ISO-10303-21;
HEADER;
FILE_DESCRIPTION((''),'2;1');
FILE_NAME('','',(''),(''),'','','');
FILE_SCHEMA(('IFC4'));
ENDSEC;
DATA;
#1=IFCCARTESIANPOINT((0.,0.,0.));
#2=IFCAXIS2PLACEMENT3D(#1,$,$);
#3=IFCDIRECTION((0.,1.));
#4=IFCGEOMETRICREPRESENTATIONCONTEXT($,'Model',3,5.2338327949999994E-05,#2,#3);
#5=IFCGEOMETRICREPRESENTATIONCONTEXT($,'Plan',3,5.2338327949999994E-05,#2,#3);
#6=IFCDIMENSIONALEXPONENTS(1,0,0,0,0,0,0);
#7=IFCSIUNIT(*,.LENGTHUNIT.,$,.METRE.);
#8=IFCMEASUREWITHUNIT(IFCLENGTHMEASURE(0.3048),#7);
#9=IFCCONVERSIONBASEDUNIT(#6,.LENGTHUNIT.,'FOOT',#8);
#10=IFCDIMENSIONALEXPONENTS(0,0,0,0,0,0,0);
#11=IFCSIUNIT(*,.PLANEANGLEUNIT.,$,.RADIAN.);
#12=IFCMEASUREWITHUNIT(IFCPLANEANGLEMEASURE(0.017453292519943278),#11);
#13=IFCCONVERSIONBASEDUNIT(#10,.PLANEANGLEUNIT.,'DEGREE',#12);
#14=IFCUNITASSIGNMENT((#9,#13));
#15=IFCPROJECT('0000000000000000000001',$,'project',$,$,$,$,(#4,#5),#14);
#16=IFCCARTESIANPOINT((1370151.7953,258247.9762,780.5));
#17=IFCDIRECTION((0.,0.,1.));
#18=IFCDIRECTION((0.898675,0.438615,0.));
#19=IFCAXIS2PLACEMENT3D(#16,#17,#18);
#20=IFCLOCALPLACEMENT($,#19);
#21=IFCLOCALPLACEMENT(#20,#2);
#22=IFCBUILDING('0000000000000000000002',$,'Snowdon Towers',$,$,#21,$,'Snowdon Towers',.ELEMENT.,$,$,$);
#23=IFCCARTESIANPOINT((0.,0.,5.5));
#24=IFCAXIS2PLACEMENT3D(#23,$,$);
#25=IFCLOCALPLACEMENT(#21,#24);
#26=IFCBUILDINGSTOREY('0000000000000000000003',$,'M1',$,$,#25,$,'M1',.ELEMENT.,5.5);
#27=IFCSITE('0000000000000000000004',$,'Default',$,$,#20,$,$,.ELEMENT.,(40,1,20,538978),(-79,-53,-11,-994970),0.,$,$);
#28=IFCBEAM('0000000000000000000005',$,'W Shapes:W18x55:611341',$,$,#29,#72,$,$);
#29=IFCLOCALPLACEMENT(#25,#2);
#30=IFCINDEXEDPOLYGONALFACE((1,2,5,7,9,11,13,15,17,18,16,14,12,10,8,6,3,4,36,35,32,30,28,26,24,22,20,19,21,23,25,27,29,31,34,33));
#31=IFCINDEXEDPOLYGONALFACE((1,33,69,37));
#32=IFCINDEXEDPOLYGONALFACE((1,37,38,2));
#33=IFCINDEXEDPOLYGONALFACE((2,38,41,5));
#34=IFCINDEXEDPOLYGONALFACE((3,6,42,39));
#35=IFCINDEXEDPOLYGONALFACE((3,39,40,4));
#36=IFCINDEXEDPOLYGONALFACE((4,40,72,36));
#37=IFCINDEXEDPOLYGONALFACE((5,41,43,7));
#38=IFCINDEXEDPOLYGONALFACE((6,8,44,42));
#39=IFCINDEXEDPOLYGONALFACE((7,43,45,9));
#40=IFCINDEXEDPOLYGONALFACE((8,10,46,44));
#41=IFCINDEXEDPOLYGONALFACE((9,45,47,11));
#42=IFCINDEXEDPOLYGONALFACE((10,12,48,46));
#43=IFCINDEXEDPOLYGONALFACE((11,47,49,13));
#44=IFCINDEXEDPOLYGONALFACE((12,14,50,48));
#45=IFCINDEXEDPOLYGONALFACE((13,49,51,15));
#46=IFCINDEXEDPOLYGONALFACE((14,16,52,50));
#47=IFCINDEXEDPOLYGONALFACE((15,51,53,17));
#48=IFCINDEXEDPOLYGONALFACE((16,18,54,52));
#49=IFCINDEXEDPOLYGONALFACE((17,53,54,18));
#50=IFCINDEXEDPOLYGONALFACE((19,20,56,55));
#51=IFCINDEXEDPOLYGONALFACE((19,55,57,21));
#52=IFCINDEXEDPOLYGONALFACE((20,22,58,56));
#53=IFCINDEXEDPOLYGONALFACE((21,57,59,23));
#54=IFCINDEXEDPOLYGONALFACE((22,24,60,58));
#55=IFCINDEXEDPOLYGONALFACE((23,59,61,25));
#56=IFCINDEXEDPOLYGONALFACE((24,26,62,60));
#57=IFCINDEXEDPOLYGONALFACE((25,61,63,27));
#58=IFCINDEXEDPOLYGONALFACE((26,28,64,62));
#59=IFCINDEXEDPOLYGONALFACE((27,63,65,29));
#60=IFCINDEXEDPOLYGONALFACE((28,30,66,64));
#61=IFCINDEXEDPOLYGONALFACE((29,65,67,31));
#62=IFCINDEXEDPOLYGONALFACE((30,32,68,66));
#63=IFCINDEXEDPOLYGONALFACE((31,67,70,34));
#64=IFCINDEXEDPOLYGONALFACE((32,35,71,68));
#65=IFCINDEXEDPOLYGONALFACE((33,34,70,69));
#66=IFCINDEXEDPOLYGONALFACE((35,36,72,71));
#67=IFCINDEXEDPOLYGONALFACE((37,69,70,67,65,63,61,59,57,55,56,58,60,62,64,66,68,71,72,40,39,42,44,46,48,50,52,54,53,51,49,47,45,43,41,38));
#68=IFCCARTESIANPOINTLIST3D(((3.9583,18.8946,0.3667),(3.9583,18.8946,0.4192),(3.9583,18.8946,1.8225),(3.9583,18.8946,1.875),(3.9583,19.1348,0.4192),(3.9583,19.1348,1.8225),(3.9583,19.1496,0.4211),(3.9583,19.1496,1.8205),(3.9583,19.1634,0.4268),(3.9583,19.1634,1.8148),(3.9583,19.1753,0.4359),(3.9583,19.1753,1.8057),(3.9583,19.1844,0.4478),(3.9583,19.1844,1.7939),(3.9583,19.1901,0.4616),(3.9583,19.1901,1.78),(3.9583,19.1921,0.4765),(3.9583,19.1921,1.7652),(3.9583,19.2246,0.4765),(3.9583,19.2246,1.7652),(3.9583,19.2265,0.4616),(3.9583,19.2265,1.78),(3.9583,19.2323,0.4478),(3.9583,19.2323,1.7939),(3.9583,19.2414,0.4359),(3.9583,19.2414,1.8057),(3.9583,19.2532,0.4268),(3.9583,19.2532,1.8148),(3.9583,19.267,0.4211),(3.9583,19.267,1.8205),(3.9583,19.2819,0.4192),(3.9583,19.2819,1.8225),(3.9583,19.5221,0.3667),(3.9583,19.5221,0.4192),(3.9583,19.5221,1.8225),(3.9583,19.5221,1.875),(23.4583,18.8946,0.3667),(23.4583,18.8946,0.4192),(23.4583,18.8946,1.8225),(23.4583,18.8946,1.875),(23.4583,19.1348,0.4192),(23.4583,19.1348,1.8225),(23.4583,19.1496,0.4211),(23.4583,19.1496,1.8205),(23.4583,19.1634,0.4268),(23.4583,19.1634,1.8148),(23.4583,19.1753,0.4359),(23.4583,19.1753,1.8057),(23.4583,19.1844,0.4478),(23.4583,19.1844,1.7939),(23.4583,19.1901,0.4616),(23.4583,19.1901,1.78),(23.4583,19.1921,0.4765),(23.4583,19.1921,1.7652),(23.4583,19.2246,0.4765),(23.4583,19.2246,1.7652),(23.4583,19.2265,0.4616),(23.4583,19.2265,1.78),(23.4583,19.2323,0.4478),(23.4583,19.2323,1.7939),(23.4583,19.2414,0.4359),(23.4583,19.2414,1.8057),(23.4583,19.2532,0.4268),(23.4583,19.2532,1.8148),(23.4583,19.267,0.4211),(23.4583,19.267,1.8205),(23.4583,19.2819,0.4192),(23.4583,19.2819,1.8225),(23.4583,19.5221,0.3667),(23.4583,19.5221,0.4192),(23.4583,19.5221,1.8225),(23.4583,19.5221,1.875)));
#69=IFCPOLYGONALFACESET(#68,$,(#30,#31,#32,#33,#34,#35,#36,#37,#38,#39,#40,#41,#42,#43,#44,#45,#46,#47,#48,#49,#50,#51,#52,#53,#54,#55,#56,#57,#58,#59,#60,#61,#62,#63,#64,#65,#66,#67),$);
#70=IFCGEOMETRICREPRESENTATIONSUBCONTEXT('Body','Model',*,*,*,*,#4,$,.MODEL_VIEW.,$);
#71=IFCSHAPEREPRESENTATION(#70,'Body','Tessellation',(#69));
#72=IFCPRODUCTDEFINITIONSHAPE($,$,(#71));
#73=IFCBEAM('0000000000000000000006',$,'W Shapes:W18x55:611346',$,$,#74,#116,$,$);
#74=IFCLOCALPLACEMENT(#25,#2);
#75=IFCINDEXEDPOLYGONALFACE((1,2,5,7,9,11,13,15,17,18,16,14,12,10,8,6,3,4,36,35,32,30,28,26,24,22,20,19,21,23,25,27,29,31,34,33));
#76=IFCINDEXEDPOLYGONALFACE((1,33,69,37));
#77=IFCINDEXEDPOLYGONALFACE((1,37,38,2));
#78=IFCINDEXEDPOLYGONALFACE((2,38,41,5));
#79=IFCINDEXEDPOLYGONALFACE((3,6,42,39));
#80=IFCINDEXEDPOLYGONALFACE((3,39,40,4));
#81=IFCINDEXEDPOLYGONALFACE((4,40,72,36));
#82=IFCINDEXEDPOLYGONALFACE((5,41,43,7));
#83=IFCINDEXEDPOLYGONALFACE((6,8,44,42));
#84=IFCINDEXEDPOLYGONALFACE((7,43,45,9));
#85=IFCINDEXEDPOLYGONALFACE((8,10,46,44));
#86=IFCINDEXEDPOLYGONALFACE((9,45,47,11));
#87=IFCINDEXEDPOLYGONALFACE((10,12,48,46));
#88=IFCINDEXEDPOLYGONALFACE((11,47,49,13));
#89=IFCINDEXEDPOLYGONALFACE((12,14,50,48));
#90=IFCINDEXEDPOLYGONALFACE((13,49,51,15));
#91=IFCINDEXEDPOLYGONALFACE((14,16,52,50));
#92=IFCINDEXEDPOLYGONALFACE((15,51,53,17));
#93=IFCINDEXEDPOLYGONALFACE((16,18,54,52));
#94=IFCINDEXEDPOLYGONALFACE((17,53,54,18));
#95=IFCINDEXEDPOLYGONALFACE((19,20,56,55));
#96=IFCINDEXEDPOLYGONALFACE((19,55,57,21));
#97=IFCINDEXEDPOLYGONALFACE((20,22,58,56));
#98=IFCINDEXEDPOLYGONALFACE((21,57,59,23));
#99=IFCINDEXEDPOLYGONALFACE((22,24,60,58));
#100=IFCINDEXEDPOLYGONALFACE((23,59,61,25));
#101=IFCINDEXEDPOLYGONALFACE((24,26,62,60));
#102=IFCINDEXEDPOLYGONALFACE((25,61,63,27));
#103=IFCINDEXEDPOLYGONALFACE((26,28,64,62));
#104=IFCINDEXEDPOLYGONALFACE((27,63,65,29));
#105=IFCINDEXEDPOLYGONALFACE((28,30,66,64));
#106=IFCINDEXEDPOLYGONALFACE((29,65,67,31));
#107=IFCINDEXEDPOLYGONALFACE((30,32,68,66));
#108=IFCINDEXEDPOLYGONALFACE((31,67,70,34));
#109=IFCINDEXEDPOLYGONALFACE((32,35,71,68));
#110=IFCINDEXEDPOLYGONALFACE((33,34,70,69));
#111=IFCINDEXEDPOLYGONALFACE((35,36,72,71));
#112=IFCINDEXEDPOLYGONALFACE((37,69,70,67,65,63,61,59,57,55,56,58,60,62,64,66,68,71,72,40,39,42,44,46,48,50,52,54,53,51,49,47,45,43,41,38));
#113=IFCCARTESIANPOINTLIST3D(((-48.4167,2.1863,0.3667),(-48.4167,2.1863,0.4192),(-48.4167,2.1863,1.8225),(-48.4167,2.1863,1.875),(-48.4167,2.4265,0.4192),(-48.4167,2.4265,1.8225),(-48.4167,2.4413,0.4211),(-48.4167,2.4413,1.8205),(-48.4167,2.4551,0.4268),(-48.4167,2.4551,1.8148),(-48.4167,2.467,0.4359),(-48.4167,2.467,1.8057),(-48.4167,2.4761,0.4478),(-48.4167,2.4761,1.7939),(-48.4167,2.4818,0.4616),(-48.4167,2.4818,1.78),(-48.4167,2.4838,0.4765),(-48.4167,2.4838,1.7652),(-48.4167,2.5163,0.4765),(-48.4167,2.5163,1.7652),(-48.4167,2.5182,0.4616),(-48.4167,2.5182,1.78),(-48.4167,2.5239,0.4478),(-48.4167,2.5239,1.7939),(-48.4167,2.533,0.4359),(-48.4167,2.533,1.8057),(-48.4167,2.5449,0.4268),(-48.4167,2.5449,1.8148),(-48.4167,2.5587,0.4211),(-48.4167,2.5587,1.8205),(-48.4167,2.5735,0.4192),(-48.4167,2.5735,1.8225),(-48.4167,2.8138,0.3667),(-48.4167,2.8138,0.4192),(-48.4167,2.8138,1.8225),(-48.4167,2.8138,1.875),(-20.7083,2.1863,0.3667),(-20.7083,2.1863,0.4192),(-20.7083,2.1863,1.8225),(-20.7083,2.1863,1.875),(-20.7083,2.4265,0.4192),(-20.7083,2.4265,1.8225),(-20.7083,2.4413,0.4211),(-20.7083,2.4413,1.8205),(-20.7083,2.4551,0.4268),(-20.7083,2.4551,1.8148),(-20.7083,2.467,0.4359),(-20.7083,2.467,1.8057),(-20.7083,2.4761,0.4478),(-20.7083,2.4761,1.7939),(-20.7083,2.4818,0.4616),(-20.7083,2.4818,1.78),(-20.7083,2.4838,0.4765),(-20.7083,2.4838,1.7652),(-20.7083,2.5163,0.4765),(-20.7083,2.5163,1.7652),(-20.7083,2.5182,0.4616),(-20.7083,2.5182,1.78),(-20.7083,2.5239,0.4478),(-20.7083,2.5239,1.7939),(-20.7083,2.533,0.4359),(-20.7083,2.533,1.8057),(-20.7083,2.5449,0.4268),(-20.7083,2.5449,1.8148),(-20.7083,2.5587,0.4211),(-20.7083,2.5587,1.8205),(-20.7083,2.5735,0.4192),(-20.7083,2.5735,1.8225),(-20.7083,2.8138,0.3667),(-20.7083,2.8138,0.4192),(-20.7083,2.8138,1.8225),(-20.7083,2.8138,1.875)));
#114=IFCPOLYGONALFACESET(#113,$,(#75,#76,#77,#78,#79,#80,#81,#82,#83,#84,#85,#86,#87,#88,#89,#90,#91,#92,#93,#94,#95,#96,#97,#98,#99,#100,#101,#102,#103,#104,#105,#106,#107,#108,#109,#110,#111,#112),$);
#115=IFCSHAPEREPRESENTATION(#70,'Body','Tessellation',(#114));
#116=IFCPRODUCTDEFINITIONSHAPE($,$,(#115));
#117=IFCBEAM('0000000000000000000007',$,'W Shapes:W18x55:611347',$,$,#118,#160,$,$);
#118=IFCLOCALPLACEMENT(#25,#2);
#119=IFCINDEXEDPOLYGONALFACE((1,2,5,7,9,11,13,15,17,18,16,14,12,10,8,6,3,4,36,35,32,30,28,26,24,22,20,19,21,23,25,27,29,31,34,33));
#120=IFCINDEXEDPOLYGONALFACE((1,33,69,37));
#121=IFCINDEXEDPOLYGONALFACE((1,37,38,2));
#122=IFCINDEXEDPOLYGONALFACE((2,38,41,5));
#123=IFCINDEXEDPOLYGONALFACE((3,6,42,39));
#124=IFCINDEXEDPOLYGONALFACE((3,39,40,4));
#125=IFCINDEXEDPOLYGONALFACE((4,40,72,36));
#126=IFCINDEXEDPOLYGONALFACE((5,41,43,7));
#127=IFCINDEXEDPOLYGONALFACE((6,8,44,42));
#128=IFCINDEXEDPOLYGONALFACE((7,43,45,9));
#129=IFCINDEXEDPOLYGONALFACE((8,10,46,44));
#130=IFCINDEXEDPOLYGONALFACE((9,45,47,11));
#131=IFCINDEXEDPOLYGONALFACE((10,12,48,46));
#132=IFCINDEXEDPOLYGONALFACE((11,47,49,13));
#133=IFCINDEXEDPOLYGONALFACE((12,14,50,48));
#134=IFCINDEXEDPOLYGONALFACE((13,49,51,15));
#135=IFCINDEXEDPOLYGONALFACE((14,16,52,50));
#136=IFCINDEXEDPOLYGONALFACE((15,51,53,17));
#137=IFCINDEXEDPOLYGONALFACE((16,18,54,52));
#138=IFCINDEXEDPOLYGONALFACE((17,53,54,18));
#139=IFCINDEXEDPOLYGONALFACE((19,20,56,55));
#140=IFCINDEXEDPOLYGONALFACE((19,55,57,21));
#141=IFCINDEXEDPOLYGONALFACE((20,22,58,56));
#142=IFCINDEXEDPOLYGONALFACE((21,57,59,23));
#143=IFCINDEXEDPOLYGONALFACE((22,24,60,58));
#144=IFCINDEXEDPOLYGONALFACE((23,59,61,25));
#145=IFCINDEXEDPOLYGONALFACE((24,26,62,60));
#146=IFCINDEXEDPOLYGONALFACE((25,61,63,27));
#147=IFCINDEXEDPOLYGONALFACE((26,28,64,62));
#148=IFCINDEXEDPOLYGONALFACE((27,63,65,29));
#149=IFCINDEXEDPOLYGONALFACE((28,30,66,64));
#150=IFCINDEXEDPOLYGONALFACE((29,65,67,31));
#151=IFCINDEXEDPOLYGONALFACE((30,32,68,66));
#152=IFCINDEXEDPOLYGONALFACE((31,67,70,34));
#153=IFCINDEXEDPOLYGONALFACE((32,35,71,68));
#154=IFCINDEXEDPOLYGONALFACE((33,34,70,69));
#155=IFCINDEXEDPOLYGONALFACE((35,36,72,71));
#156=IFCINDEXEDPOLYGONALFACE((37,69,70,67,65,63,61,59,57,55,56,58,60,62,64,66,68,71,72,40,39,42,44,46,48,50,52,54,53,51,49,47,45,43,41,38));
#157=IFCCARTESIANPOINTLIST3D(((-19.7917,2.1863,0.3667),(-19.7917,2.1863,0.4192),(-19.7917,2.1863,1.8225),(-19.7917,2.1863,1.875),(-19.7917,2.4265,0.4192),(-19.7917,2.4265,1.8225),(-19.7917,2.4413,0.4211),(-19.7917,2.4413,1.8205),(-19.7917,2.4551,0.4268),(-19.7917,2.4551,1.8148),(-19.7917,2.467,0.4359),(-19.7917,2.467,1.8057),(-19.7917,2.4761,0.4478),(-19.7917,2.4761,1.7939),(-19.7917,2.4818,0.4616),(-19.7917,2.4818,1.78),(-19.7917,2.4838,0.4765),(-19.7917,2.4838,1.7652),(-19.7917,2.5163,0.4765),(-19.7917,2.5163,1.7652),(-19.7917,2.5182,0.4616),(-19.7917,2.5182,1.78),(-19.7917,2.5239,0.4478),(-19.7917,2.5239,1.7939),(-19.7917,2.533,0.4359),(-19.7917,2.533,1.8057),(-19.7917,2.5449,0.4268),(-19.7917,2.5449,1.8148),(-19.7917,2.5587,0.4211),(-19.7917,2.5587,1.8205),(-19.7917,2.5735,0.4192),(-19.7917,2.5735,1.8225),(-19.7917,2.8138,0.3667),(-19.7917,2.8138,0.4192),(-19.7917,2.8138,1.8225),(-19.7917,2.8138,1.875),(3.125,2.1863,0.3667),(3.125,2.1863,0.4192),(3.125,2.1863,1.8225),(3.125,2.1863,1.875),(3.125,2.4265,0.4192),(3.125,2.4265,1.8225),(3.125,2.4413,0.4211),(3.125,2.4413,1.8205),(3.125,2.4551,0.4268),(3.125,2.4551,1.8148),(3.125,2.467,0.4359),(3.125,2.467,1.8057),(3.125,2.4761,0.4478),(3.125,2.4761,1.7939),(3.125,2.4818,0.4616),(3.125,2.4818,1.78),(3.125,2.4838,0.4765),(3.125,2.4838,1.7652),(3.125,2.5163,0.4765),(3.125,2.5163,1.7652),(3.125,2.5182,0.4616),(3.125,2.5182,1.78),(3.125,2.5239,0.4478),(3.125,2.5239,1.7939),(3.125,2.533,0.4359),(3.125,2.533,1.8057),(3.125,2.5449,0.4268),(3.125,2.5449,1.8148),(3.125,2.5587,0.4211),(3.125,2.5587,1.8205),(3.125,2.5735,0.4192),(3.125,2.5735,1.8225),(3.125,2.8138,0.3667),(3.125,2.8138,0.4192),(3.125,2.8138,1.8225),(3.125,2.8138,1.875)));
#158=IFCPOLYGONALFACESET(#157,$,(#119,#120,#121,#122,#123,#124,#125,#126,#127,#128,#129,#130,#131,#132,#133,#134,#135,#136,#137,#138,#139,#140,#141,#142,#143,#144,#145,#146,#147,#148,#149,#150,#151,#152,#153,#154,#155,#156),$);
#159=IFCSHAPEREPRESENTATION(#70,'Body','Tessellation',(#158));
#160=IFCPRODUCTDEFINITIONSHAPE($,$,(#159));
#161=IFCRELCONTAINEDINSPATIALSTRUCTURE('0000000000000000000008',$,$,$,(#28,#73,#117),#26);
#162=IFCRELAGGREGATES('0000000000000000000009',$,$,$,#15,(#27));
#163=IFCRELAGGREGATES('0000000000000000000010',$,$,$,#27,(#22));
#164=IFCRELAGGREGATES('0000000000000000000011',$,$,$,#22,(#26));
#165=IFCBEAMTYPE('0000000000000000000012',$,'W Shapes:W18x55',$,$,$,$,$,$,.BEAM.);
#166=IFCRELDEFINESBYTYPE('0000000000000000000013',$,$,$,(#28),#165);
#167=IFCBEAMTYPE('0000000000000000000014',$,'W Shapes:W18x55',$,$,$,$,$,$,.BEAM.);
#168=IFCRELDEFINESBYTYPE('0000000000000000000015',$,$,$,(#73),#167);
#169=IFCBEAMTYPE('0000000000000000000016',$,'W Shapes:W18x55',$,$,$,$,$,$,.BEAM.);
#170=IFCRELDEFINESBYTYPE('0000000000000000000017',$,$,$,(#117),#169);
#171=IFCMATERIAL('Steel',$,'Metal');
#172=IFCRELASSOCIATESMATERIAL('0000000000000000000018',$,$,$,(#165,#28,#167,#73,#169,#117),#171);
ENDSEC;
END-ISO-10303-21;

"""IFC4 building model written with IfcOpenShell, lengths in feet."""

from ifc_helpers import new_model, entity, si_unit, converted_unit, direction, frame, origin, place, context, subcontext, project, spatial, line, arc, indexed_curve, outline, extrude, source, transform, mapped, material, type_object, type_shapes, element, save


model = new_model("IFC4")

# Units and contexts
model_context = context("Model", 3, precision=5.2338327949999994e-05, world=origin(), true_north=direction((0.0, 1.0)))
plan_context = context("Plan", 3, precision=5.2338327949999994e-05, world=origin(), true_north=direction((0.0, 1.0)))
body_context = subcontext(model_context, "Body", "Model", "MODEL_VIEW")
ifc_project = project(units=[converted_unit("LENGTHUNIT", "FOOT", entity("IfcLengthMeasure", 0.3048), si_unit("LENGTHUNIT", "METRE"), dimensions=[1, 0, 0, 0, 0, 0, 0]), converted_unit("PLANEANGLEUNIT", "DEGREE", entity("IfcPlaneAngleMeasure", 0.017453292519943278), si_unit("PLANEANGLEUNIT", "RADIAN"), dimensions=[0, 0, 0, 0, 0, 0, 0])], contexts=[model_context, plan_context])

# Site, building, storey
site_placement = place(None, frame((1370151.7953, 258247.9762, 780.5), z_axis=(0.0, 0.0, 1.0), x_axis=(0.898675, 0.438615, 0.0)))
site = spatial("IfcSite", under=ifc_project, at=site_placement, Name="Default", CompositionType="ELEMENT", RefLatitude=(40, 1, 20, 538978), RefLongitude=(-79, -53, -11, -994970), RefElevation=0.0)
building_placement = place(site_placement, origin())
building = spatial("IfcBuilding", under=site, at=building_placement, Name="Snowdon Towers", LongName="Snowdon Towers", CompositionType="ELEMENT")
storey_placement = place(building_placement, frame((0.0, 0.0, 5.5)))
storey = spatial("IfcBuildingStorey", under=building, at=storey_placement, Name="M1", LongName="M1", CompositionType="ELEMENT", Elevation=5.5)

# Beams
ifc_material_1 = material(Name="Steel", Category="Metal")
beam_type_1 = type_object("IfcBeamType", Name="W Shapes:W18x55", PredefinedType="BEAM", material=ifc_material_1)
shared_shape_1 = source(origin(), body_context, "Body", "SweptSolid", [
    extrude(outline(indexed_curve([(-0.7542, -0.3138), (-0.7017, -0.3138), (-0.7017, -0.0735), (-0.6849, -0.033), (-0.6444, -0.0162), (0.6444, -0.0162), (0.6849, -0.033), (0.7017, -0.0735), (0.7017, -0.3138), (0.7542, -0.3138), (0.7542, 0.3138), (0.7017, 0.3138), (0.7017, 0.0735), (0.6849, 0.033), (0.6444, 0.0163), (-0.6444, 0.0163), (-0.6849, 0.033), (-0.7017, 0.0735), (-0.7017, 0.3137), (-0.7542, 0.3137)], segments=[line(1, 2, 3), arc(3, 4, 5), line(5, 6), arc(6, 7, 8), line(8, 9, 10, 11, 12, 13), arc(13, 14, 15), line(15, 16), arc(16, 17, 18), line(18, 19, 20, 1)], self_intersect=False)), frame((-9.75, 0.0, 0.0), z_axis=(1.0, 0.0, 0.0), x_axis=(0.0, 0.0, -1.0)), (0.0, 0.0, 1.0), 19.5),
])
type_shapes(beam_type_1, [shared_shape_1])
beam_1_placement = place(storey_placement, frame((13.7083, 19.2083, 1.1208)))
element("IfcBeam", 1, at=beam_1_placement, inside=storey, type_object=beam_type_1, material=ifc_material_1, Name="W Shapes:W18x55:611341", context=body_context, shape_type="MappedRepresentation", body=[
    mapped(shared_shape_1, transform((0.0, 0.0, 0.0), scale=1.0)),
])
beam_type_2 = type_object("IfcBeamType", Name="W Shapes:W18x55", PredefinedType="BEAM", material=ifc_material_1)
shared_shape_2 = source(origin(), body_context, "Body", "SweptSolid", [
    extrude(outline(indexed_curve([(-0.7542, -0.3138), (-0.7017, -0.3138), (-0.7017, -0.0735), (-0.6849, -0.033), (-0.6444, -0.0162), (0.6444, -0.0162), (0.6849, -0.033), (0.7017, -0.0735), (0.7017, -0.3138), (0.7542, -0.3138), (0.7542, 0.3138), (0.7017, 0.3138), (0.7017, 0.0735), (0.6849, 0.033), (0.6444, 0.0163), (-0.6444, 0.0163), (-0.6849, 0.033), (-0.7017, 0.0735), (-0.7017, 0.3137), (-0.7542, 0.3137)], segments=[line(1, 2, 3), arc(3, 4, 5), line(5, 6), arc(6, 7, 8), line(8, 9, 10, 11, 12, 13), arc(13, 14, 15), line(15, 16), arc(16, 17, 18), line(18, 19, 20, 1)], self_intersect=False)), frame((-13.6667, 0.0, 0.0), z_axis=(1.0, 0.0, 0.0), x_axis=(0.0, 0.0, -1.0)), (0.0, 0.0, 1.0), 27.7083),
])
type_shapes(beam_type_2, [shared_shape_2])
beam_2_placement = place(storey_placement, frame((-34.75, 2.5, 1.1208)))
element("IfcBeam", 2, at=beam_2_placement, inside=storey, type_object=beam_type_2, material=ifc_material_1, Name="W Shapes:W18x55:611346", context=body_context, shape_type="MappedRepresentation", body=[
    mapped(shared_shape_2, transform((0.0, 0.0, 0.0), scale=1.0)),
])
beam_type_3 = type_object("IfcBeamType", Name="W Shapes:W18x55", PredefinedType="BEAM", material=ifc_material_1)
shared_shape_3 = source(origin(), body_context, "Body", "SweptSolid", [
    extrude(outline(indexed_curve([(-0.7542, -0.3138), (-0.7017, -0.3138), (-0.7017, -0.0735), (-0.6849, -0.033), (-0.6444, -0.0162), (0.6444, -0.0162), (0.6849, -0.033), (0.7017, -0.0735), (0.7017, -0.3138), (0.7542, -0.3138), (0.7542, 0.3138), (0.7017, 0.3138), (0.7017, 0.0735), (0.6849, 0.033), (0.6444, 0.0163), (-0.6444, 0.0163), (-0.6849, 0.033), (-0.7017, 0.0735), (-0.7017, 0.3137), (-0.7542, 0.3137)], segments=[line(1, 2, 3), arc(3, 4, 5), line(5, 6), arc(6, 7, 8), line(8, 9, 10, 11, 12, 13), arc(13, 14, 15), line(15, 16), arc(16, 17, 18), line(18, 19, 20, 1)], self_intersect=False)), frame((-11.5417, 0.0, 0.0), z_axis=(1.0, 0.0, 0.0), x_axis=(0.0, 0.0, -1.0)), (0.0, 0.0, 1.0), 22.9167),
])
type_shapes(beam_type_3, [shared_shape_3])
beam_3_placement = place(storey_placement, frame((-8.25, 2.5, 1.1208)))
element("IfcBeam", 3, at=beam_3_placement, inside=storey, type_object=beam_type_3, material=ifc_material_1, Name="W Shapes:W18x55:611347", context=body_context, shape_type="MappedRepresentation", body=[
    mapped(shared_shape_3, transform((0.0, 0.0, 0.0), scale=1.0)),
])

save(model, "model.ifc")
